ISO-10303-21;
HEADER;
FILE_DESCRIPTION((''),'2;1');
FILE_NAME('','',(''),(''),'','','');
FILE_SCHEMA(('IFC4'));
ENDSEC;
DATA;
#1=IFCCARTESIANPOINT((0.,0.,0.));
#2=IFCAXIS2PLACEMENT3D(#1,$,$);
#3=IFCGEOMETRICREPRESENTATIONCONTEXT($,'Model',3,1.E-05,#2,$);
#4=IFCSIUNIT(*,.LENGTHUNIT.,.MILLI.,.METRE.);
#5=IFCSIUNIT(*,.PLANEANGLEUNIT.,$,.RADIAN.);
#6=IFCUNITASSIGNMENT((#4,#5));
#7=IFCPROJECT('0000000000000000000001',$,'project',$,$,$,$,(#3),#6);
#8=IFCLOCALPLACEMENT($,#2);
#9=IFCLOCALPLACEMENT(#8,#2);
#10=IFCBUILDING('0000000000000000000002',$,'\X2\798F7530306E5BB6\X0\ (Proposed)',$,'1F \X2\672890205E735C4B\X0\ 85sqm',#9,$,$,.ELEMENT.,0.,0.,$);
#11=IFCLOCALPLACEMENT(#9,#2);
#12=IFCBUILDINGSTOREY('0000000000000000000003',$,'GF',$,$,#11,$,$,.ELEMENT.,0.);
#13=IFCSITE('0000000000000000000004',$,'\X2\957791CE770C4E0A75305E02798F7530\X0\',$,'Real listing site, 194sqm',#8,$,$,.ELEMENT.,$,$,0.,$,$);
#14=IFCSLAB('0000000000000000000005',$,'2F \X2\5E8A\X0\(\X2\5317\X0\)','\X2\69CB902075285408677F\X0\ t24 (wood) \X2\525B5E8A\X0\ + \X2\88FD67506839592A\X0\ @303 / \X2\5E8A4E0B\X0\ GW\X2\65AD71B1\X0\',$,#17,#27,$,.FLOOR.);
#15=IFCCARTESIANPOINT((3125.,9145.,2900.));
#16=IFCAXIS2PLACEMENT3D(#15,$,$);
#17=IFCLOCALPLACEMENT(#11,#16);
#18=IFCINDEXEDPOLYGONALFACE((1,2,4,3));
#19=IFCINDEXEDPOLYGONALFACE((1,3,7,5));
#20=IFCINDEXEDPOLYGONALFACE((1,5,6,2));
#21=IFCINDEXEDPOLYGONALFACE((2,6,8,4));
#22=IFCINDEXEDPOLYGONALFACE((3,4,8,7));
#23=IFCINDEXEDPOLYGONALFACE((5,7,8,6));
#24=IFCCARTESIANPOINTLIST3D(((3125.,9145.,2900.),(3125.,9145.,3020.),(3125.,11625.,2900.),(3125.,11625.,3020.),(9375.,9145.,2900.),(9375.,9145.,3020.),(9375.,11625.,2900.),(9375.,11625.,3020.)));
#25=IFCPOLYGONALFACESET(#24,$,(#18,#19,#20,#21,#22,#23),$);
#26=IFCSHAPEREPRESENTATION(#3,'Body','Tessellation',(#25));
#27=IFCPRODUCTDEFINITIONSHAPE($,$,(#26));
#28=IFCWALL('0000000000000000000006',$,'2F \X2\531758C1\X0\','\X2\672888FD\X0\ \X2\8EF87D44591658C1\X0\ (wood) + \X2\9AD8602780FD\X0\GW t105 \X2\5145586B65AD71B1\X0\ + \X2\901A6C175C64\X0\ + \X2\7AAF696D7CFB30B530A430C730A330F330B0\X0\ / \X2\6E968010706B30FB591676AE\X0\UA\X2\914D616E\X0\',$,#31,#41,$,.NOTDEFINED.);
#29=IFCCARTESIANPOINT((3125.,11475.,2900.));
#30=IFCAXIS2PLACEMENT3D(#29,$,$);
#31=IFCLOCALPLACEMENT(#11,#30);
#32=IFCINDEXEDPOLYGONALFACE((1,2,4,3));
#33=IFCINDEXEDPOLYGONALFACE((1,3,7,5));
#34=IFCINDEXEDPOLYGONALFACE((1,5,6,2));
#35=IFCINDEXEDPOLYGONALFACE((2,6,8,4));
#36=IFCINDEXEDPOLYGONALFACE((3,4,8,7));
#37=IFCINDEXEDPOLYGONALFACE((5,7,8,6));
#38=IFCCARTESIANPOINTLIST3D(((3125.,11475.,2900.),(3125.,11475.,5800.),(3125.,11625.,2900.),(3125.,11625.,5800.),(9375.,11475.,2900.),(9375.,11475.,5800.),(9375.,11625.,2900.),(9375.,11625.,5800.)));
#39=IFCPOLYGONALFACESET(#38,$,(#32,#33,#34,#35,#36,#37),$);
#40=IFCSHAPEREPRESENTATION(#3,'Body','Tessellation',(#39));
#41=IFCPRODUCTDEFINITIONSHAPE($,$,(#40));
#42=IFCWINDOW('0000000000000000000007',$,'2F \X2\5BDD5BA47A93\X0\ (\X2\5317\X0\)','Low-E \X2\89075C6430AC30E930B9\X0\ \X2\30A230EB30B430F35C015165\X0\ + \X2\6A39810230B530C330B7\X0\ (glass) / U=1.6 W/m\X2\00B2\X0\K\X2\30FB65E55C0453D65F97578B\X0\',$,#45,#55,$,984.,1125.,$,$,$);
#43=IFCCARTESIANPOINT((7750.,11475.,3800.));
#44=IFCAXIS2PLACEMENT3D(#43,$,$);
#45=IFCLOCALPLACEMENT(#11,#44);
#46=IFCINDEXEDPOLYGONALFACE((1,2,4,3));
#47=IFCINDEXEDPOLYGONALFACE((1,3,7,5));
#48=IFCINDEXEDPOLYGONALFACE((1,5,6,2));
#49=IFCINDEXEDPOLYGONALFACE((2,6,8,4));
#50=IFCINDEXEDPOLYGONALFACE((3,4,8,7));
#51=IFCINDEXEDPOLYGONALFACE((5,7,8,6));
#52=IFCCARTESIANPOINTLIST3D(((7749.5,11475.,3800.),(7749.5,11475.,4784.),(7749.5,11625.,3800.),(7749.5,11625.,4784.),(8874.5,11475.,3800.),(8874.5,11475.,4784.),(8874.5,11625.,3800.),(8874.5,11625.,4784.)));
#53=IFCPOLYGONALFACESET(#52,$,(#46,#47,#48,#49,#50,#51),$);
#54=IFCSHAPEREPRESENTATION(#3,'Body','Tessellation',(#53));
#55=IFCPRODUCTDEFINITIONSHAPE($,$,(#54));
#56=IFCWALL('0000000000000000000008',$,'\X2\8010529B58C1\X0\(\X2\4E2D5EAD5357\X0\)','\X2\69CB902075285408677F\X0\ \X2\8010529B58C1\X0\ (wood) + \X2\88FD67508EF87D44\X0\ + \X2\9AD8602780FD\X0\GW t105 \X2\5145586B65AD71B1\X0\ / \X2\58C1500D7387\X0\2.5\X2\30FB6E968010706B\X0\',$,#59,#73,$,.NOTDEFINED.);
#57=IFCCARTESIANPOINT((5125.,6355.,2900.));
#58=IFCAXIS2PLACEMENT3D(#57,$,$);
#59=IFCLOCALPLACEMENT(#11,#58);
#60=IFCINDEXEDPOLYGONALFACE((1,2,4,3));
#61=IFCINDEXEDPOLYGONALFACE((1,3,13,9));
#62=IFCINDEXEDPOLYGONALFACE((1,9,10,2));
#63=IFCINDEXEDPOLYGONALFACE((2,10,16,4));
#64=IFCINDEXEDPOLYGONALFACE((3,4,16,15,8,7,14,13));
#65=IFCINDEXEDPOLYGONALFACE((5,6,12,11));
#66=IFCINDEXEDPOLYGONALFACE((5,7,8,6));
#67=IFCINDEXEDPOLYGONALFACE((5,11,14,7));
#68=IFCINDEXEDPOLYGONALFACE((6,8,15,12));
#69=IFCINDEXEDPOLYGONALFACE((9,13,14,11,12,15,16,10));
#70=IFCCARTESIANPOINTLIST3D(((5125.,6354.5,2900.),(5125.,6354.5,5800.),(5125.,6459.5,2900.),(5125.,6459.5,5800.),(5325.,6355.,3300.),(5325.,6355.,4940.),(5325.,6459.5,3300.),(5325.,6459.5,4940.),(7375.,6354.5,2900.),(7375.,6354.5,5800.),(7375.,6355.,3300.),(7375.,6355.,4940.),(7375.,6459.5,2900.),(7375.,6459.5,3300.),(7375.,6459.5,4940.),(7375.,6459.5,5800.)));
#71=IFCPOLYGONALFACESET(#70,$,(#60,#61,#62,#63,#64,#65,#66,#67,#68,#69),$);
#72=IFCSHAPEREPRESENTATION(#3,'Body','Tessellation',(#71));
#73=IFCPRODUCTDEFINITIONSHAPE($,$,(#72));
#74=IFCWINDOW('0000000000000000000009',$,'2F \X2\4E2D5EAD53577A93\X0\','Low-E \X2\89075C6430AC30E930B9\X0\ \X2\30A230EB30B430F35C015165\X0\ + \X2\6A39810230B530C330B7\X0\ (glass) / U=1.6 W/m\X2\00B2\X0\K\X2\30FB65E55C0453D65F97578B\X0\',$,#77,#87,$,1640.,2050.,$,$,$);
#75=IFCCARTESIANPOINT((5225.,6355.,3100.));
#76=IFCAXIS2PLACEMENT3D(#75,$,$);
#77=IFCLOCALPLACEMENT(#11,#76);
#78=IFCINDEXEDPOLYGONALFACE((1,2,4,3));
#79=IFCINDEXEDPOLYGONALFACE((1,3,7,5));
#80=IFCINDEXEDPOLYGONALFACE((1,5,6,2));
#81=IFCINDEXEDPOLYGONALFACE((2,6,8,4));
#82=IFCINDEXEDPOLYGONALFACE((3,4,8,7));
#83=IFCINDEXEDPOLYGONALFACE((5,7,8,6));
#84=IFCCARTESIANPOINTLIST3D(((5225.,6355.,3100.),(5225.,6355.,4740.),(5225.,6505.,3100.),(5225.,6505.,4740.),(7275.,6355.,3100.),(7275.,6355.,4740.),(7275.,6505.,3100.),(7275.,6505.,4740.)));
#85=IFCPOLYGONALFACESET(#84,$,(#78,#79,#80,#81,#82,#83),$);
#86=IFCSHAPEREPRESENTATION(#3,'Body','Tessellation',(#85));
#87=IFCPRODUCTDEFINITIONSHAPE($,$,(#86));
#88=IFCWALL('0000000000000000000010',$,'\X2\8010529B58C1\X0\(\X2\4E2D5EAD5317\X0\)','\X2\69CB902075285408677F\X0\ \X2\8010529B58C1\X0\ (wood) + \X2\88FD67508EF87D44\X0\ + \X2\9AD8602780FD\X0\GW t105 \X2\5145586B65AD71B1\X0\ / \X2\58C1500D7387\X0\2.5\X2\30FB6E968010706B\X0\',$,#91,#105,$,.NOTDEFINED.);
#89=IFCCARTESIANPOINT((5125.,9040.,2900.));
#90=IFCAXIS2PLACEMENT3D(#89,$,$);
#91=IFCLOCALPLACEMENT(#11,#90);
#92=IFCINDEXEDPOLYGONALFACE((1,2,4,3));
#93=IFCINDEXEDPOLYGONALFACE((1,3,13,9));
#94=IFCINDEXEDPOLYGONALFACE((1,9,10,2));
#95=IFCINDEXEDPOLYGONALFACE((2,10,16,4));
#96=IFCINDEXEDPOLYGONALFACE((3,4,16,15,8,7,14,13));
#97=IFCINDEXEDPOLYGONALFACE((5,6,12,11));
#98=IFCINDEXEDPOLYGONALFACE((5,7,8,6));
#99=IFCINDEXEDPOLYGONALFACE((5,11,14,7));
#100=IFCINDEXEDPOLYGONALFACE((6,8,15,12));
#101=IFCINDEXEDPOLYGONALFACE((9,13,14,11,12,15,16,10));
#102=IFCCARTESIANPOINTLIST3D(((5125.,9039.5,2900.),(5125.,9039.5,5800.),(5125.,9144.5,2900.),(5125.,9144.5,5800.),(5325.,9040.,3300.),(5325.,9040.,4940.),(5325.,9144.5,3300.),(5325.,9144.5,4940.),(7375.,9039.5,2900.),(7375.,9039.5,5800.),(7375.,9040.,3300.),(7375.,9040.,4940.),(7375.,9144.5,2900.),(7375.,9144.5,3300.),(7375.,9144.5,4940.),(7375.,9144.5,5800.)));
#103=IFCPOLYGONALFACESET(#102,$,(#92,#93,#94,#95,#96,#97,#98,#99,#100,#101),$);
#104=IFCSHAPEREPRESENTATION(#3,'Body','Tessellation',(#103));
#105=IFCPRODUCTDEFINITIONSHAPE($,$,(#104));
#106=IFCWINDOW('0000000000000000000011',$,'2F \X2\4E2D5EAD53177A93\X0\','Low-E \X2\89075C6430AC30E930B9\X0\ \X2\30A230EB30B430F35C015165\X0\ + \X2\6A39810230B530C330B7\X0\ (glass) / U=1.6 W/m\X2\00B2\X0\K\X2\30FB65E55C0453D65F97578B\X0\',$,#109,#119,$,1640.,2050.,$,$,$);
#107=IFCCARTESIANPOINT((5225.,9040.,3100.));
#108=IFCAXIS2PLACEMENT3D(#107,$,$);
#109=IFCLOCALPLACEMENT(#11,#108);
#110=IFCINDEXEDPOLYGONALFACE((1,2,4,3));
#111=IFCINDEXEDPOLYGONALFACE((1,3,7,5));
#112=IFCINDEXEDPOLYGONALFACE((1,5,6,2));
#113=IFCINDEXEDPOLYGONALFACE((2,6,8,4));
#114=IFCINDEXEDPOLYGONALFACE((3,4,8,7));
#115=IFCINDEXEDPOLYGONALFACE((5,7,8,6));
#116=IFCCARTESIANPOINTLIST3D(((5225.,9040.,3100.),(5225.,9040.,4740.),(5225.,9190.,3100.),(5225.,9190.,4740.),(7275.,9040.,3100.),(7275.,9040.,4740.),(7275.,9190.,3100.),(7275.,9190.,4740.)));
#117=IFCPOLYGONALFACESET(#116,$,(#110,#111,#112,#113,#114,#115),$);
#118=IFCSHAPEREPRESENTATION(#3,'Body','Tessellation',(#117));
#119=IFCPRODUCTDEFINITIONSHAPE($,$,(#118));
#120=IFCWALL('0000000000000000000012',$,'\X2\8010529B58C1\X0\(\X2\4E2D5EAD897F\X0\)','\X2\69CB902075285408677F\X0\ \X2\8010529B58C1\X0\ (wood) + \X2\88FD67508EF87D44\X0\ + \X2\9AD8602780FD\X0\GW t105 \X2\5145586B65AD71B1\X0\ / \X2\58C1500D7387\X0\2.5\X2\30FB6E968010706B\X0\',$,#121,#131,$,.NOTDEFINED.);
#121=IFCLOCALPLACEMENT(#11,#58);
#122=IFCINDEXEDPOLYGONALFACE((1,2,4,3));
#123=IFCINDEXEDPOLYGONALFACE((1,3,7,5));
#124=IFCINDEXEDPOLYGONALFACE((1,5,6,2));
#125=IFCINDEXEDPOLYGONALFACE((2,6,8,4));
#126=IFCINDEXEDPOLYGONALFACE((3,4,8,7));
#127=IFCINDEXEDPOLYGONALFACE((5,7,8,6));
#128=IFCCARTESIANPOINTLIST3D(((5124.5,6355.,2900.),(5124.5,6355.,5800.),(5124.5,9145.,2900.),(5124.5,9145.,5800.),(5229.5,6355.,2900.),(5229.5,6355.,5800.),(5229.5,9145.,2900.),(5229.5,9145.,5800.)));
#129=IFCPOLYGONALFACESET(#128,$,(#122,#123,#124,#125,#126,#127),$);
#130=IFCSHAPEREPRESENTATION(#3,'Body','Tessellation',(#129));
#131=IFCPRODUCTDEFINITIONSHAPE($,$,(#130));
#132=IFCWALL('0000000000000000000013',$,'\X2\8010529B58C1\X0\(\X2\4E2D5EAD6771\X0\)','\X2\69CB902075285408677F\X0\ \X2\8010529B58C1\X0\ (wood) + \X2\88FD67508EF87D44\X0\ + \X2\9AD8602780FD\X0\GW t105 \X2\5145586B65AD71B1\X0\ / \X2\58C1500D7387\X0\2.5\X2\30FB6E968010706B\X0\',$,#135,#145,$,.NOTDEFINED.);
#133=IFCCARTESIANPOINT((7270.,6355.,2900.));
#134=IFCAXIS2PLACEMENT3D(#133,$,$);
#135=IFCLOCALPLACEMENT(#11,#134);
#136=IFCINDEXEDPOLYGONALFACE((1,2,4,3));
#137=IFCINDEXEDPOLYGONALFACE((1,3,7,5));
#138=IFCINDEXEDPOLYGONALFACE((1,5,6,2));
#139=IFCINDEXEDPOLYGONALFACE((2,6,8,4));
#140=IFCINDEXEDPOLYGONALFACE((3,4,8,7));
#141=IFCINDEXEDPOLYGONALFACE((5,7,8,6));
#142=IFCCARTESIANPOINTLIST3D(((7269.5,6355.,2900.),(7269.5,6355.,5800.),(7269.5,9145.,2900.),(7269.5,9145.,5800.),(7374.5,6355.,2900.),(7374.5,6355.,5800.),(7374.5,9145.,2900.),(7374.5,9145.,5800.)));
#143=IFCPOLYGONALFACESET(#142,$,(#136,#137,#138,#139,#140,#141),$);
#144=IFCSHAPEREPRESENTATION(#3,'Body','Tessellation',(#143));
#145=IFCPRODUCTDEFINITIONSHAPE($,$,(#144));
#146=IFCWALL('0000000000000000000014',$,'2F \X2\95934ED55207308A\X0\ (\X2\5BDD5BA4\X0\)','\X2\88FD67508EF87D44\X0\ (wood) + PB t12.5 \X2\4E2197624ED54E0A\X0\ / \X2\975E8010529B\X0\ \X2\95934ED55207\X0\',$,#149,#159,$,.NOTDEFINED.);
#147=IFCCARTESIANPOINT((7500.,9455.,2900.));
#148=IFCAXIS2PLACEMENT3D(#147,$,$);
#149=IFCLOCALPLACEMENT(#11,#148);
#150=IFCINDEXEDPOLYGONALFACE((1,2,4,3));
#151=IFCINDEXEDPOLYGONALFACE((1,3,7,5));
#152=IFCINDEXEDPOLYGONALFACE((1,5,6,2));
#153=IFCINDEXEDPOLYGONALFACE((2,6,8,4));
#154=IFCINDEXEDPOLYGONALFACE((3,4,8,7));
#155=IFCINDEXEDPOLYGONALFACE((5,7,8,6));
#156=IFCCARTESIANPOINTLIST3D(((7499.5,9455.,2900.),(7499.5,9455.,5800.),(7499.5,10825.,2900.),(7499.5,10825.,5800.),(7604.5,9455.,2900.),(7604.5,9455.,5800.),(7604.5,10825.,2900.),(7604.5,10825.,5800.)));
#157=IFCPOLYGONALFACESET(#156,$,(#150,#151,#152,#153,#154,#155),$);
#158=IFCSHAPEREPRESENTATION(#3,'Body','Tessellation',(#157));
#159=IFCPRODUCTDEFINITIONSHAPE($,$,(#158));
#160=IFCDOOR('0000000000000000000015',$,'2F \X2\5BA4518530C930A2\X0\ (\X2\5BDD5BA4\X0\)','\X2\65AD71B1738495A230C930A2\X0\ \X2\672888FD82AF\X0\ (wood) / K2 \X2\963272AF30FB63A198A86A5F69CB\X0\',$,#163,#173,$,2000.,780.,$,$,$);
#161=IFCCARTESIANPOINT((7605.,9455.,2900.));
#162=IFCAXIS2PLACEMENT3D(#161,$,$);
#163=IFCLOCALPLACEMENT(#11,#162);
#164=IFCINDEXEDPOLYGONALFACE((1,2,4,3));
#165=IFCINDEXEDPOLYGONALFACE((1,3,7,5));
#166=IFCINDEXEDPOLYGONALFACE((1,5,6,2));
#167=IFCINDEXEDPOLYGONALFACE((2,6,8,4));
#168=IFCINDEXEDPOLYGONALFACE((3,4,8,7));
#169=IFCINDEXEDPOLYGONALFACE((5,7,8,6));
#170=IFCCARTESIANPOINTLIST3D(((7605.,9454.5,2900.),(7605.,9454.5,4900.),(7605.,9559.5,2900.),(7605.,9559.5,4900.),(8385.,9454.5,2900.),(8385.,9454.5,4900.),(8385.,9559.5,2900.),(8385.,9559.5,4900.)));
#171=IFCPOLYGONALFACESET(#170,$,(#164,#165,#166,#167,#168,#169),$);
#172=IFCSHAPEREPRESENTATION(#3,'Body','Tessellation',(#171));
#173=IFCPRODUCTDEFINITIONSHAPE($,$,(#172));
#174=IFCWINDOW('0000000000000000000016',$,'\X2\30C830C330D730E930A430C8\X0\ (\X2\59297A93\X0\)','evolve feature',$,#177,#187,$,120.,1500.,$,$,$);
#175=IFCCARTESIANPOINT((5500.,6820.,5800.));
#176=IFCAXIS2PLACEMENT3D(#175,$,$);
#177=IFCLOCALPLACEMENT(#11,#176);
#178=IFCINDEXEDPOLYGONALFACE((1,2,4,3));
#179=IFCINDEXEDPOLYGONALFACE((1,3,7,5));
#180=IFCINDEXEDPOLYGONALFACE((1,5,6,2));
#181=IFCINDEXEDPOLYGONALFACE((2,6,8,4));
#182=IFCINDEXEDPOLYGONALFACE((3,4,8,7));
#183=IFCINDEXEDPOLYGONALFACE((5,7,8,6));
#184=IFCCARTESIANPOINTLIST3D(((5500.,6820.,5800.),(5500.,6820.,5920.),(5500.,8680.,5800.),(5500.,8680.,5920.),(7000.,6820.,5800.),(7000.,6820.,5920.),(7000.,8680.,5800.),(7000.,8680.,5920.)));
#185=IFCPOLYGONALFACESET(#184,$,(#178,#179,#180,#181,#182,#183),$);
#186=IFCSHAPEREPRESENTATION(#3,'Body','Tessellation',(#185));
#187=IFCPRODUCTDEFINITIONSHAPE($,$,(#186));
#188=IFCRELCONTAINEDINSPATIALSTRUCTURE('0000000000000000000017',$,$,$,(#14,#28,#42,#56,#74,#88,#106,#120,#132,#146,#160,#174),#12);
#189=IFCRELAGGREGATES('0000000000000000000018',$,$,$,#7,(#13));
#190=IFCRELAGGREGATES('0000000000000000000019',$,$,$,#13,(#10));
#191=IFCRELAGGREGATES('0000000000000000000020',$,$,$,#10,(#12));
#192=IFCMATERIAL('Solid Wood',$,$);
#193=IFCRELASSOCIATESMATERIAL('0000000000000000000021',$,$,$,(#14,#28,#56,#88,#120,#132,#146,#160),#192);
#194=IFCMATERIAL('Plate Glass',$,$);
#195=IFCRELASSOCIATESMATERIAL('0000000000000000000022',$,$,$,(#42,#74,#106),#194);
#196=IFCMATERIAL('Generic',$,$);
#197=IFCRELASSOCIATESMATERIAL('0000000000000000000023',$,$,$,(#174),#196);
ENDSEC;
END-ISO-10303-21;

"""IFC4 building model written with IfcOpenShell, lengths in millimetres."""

from ifc_helpers import new_model, si_unit, frame, frame_2d, origin, place, context, project, spatial, rectangle, extrude, material, element, fill, save


model = new_model("IFC4")

# Units and contexts
model_context = context("Model", 3, precision=1e-05, world=origin())
ifc_project = project(units=[si_unit("LENGTHUNIT", "METRE", prefix="MILLI"), si_unit("PLANEANGLEUNIT", "RADIAN")], contexts=[model_context])

# Site, building, storey
site_placement = place(None, origin())
site = spatial("IfcSite", under=ifc_project, at=site_placement, Name="長野県上田市福田", ObjectType="Real listing site, 194sqm", CompositionType="ELEMENT", RefElevation=0.0)
building_placement = place(site_placement, origin())
building = spatial("IfcBuilding", under=site, at=building_placement, Name="福田の家 (Proposed)", ObjectType="1F 木造平屋 85sqm", CompositionType="ELEMENT", ElevationOfRefHeight=0.0, ElevationOfTerrain=0.0)
storey_placement = place(building_placement, origin())
storey = spatial("IfcBuildingStorey", under=building, at=storey_placement, Name="GF", CompositionType="ELEMENT", Elevation=0.0)

# Slab
ifc_material_1 = material(Name="Solid Wood")
slab_placement = place(storey_placement, frame((3125.0, 9145.0, 2900.0)))
element("IfcSlab", 1, at=slab_placement, inside=storey, material=ifc_material_1, Name="2F 床(北)", Description="構造用合板 t24 (wood) 剛床 + 製材根太 @303 / 床下 GW断熱", PredefinedType="FLOOR", context=model_context, shape_type="SweptSolid", body=[
    extrude(rectangle(XDim=6250.0, YDim=2480.0, at=frame_2d((3125.0, 1240.0))), frame((3125.0, 9145.0, 2900.0)), (0.0, 0.0, 1.0), 120.0),
])

# Walls, openings, windows
wall_1_placement = place(storey_placement, frame((3125.0, 11475.0, 2900.0)))
wall_1 = element("IfcWall", 2, at=wall_1_placement, inside=storey, material=ifc_material_1, Name="2F 北壁", Description="木製 軸組外壁 (wood) + 高性能GW t105 充填断熱 + 通気層 + 窯業系サイディング / 準耐火・外皮UA配慮", PredefinedType="NOTDEFINED", context=model_context, shape_type="SweptSolid", body=[
    extrude(rectangle(XDim=6250.0, YDim=150.0, at=frame_2d((3125.0, 75.0))), frame((3125.0, 11475.0, 2900.0)), (0.0, 0.0, 1.0), 2900.0),
])
opening_1_placement = place(storey_placement, frame((7750.0, 11475.0, 3800.0)))
opening_1 = element("IfcOpeningElement", 3, at=opening_1_placement, cuts=wall_1, PredefinedType="NOTDEFINED", context=model_context, shape_type="SweptSolid", body=[
    extrude(rectangle(XDim=1125.0, YDim=150.0, at=frame_2d((562.0, 75.0))), frame((7750.0, 11475.0, 3800.0)), (0.0, 0.0, 1.0), 984.0),
])
ifc_material_2 = material(Name="Plate Glass")
window_1_placement = place(storey_placement, frame((7750.0, 11475.0, 3800.0)))
window_1 = element("IfcWindow", 4, at=window_1_placement, inside=storey, material=ifc_material_2, Name="2F 寝室窓 (北)", Description="Low-E 複層ガラス アルゴン封入 + 樹脂サッシ (glass) / U=1.6 W/m²K・日射取得型", OverallHeight=984.0, OverallWidth=1125.0, context=model_context, shape_type="SweptSolid", body=[
    extrude(rectangle(XDim=1125.0, YDim=150.0, at=frame_2d((562.0, 75.0))), frame((7750.0, 11475.0, 3800.0)), (0.0, 0.0, 1.0), 984.0),
])
fill(opening_1, window_1)
wall_2_placement = place(storey_placement, frame((5125.0, 6355.0, 2900.0)))
wall_2 = element("IfcWall", 5, at=wall_2_placement, inside=storey, material=ifc_material_1, Name="耐力壁(中庭南)", Description="構造用合板 耐力壁 (wood) + 製材軸組 + 高性能GW t105 充填断熱 / 壁倍率2.5・準耐火", PredefinedType="NOTDEFINED", context=model_context, shape_type="SweptSolid", body=[
    extrude(rectangle(XDim=2250.0, YDim=105.0, at=frame_2d((1125.0, 52.0))), frame((5125.0, 6355.0, 2900.0)), (0.0, 0.0, 1.0), 2900.0),
])
opening_2_placement = place(storey_placement, frame((5225.0, 6355.0, 3100.0)))
opening_2 = element("IfcOpeningElement", 6, at=opening_2_placement, cuts=wall_2, PredefinedType="NOTDEFINED", context=model_context, shape_type="SweptSolid", body=[
    extrude(rectangle(XDim=2050.0, YDim=150.0, at=frame_2d((1025.0, 75.0))), frame((5225.0, 6355.0, 3100.0)), (0.0, 0.0, 1.0), 1640.0),
])
window_2_placement = place(storey_placement, frame((5225.0, 6355.0, 3100.0)))
window_2 = element("IfcWindow", 7, at=window_2_placement, inside=storey, material=ifc_material_2, Name="2F 中庭南窓", Description="Low-E 複層ガラス アルゴン封入 + 樹脂サッシ (glass) / U=1.6 W/m²K・日射取得型", OverallHeight=1640.0, OverallWidth=2050.0, context=model_context, shape_type="SweptSolid", body=[
    extrude(rectangle(XDim=2050.0, YDim=150.0, at=frame_2d((1025.0, 75.0))), frame((5225.0, 6355.0, 3100.0)), (0.0, 0.0, 1.0), 1640.0),
])
fill(opening_2, window_2)
wall_3_placement = place(storey_placement, frame((5125.0, 9040.0, 2900.0)))
wall_3 = element("IfcWall", 8, at=wall_3_placement, inside=storey, material=ifc_material_1, Name="耐力壁(中庭北)", Description="構造用合板 耐力壁 (wood) + 製材軸組 + 高性能GW t105 充填断熱 / 壁倍率2.5・準耐火", PredefinedType="NOTDEFINED", context=model_context, shape_type="SweptSolid", body=[
    extrude(rectangle(XDim=2250.0, YDim=105.0, at=frame_2d((1125.0, 52.0))), frame((5125.0, 9040.0, 2900.0)), (0.0, 0.0, 1.0), 2900.0),
])
opening_3_placement = place(storey_placement, frame((5225.0, 9040.0, 3100.0)))
opening_3 = element("IfcOpeningElement", 9, at=opening_3_placement, cuts=wall_3, PredefinedType="NOTDEFINED", context=model_context, shape_type="SweptSolid", body=[
    extrude(rectangle(XDim=2050.0, YDim=150.0, at=frame_2d((1025.0, 75.0))), frame((5225.0, 9040.0, 3100.0)), (0.0, 0.0, 1.0), 1640.0),
])
window_3_placement = place(storey_placement, frame((5225.0, 9040.0, 3100.0)))
window_3 = element("IfcWindow", 10, at=window_3_placement, inside=storey, material=ifc_material_2, Name="2F 中庭北窓", Description="Low-E 複層ガラス アルゴン封入 + 樹脂サッシ (glass) / U=1.6 W/m²K・日射取得型", OverallHeight=1640.0, OverallWidth=2050.0, context=model_context, shape_type="SweptSolid", body=[
    extrude(rectangle(XDim=2050.0, YDim=150.0, at=frame_2d((1025.0, 75.0))), frame((5225.0, 9040.0, 3100.0)), (0.0, 0.0, 1.0), 1640.0),
])
fill(opening_3, window_3)

# Walls
wall_4_placement = place(storey_placement, frame((5125.0, 6355.0, 2900.0)))
element("IfcWall", 11, at=wall_4_placement, inside=storey, material=ifc_material_1, Name="耐力壁(中庭西)", Description="構造用合板 耐力壁 (wood) + 製材軸組 + 高性能GW t105 充填断熱 / 壁倍率2.5・準耐火", PredefinedType="NOTDEFINED", context=model_context, shape_type="SweptSolid", body=[
    extrude(rectangle(XDim=105.0, YDim=2790.0, at=frame_2d((52.0, 1395.0))), frame((5125.0, 6355.0, 2900.0)), (0.0, 0.0, 1.0), 2900.0),
])
wall_5_placement = place(storey_placement, frame((7270.0, 6355.0, 2900.0)))
element("IfcWall", 12, at=wall_5_placement, inside=storey, material=ifc_material_1, Name="耐力壁(中庭東)", Description="構造用合板 耐力壁 (wood) + 製材軸組 + 高性能GW t105 充填断熱 / 壁倍率2.5・準耐火", PredefinedType="NOTDEFINED", context=model_context, shape_type="SweptSolid", body=[
    extrude(rectangle(XDim=105.0, YDim=2790.0, at=frame_2d((52.0, 1395.0))), frame((7270.0, 6355.0, 2900.0)), (0.0, 0.0, 1.0), 2900.0),
])
wall_6_placement = place(storey_placement, frame((7500.0, 9455.0, 2900.0)))
element("IfcWall", 13, at=wall_6_placement, inside=storey, material=ifc_material_1, Name="2F 間仕切り (寝室)", Description="製材軸組 (wood) + PB t12.5 両面仕上 / 非耐力 間仕切", PredefinedType="NOTDEFINED", context=model_context, shape_type="SweptSolid", body=[
    extrude(rectangle(XDim=105.0, YDim=1370.0, at=frame_2d((52.0, 685.0))), frame((7500.0, 9455.0, 2900.0)), (0.0, 0.0, 1.0), 2900.0),
])

# Door
door_placement = place(storey_placement, frame((7605.0, 9455.0, 2900.0)))
element("IfcDoor", 14, at=door_placement, inside=storey, material=ifc_material_1, Name="2F 室内ドア (寝室)", Description="断熱玄関ドア 木製芯 (wood) / K2 防犯・採風機構", OverallHeight=2000.0, OverallWidth=780.0, context=model_context, shape_type="SweptSolid", body=[
    extrude(rectangle(XDim=780.0, YDim=105.0, at=frame_2d((390.0, 52.0))), frame((7605.0, 9455.0, 2900.0)), (0.0, 0.0, 1.0), 2000.0),
])

# Window
ifc_material_3 = material(Name="Generic")
window_4_placement = place(storey_placement, frame((5500.0, 6820.0, 5800.0)))
element("IfcWindow", 15, at=window_4_placement, inside=storey, material=ifc_material_3, Name="トップライト (天窓)", Description="evolve feature", OverallHeight=120.0, OverallWidth=1500.0, context=model_context, shape_type="SweptSolid", body=[
    extrude(rectangle(XDim=1500.0, YDim=1860.0, at=frame_2d((750.0, 930.0))), frame((5500.0, 6820.0, 5800.0)), (0.0, 0.0, 1.0), 120.0),
])

save(model, "model.ifc")
